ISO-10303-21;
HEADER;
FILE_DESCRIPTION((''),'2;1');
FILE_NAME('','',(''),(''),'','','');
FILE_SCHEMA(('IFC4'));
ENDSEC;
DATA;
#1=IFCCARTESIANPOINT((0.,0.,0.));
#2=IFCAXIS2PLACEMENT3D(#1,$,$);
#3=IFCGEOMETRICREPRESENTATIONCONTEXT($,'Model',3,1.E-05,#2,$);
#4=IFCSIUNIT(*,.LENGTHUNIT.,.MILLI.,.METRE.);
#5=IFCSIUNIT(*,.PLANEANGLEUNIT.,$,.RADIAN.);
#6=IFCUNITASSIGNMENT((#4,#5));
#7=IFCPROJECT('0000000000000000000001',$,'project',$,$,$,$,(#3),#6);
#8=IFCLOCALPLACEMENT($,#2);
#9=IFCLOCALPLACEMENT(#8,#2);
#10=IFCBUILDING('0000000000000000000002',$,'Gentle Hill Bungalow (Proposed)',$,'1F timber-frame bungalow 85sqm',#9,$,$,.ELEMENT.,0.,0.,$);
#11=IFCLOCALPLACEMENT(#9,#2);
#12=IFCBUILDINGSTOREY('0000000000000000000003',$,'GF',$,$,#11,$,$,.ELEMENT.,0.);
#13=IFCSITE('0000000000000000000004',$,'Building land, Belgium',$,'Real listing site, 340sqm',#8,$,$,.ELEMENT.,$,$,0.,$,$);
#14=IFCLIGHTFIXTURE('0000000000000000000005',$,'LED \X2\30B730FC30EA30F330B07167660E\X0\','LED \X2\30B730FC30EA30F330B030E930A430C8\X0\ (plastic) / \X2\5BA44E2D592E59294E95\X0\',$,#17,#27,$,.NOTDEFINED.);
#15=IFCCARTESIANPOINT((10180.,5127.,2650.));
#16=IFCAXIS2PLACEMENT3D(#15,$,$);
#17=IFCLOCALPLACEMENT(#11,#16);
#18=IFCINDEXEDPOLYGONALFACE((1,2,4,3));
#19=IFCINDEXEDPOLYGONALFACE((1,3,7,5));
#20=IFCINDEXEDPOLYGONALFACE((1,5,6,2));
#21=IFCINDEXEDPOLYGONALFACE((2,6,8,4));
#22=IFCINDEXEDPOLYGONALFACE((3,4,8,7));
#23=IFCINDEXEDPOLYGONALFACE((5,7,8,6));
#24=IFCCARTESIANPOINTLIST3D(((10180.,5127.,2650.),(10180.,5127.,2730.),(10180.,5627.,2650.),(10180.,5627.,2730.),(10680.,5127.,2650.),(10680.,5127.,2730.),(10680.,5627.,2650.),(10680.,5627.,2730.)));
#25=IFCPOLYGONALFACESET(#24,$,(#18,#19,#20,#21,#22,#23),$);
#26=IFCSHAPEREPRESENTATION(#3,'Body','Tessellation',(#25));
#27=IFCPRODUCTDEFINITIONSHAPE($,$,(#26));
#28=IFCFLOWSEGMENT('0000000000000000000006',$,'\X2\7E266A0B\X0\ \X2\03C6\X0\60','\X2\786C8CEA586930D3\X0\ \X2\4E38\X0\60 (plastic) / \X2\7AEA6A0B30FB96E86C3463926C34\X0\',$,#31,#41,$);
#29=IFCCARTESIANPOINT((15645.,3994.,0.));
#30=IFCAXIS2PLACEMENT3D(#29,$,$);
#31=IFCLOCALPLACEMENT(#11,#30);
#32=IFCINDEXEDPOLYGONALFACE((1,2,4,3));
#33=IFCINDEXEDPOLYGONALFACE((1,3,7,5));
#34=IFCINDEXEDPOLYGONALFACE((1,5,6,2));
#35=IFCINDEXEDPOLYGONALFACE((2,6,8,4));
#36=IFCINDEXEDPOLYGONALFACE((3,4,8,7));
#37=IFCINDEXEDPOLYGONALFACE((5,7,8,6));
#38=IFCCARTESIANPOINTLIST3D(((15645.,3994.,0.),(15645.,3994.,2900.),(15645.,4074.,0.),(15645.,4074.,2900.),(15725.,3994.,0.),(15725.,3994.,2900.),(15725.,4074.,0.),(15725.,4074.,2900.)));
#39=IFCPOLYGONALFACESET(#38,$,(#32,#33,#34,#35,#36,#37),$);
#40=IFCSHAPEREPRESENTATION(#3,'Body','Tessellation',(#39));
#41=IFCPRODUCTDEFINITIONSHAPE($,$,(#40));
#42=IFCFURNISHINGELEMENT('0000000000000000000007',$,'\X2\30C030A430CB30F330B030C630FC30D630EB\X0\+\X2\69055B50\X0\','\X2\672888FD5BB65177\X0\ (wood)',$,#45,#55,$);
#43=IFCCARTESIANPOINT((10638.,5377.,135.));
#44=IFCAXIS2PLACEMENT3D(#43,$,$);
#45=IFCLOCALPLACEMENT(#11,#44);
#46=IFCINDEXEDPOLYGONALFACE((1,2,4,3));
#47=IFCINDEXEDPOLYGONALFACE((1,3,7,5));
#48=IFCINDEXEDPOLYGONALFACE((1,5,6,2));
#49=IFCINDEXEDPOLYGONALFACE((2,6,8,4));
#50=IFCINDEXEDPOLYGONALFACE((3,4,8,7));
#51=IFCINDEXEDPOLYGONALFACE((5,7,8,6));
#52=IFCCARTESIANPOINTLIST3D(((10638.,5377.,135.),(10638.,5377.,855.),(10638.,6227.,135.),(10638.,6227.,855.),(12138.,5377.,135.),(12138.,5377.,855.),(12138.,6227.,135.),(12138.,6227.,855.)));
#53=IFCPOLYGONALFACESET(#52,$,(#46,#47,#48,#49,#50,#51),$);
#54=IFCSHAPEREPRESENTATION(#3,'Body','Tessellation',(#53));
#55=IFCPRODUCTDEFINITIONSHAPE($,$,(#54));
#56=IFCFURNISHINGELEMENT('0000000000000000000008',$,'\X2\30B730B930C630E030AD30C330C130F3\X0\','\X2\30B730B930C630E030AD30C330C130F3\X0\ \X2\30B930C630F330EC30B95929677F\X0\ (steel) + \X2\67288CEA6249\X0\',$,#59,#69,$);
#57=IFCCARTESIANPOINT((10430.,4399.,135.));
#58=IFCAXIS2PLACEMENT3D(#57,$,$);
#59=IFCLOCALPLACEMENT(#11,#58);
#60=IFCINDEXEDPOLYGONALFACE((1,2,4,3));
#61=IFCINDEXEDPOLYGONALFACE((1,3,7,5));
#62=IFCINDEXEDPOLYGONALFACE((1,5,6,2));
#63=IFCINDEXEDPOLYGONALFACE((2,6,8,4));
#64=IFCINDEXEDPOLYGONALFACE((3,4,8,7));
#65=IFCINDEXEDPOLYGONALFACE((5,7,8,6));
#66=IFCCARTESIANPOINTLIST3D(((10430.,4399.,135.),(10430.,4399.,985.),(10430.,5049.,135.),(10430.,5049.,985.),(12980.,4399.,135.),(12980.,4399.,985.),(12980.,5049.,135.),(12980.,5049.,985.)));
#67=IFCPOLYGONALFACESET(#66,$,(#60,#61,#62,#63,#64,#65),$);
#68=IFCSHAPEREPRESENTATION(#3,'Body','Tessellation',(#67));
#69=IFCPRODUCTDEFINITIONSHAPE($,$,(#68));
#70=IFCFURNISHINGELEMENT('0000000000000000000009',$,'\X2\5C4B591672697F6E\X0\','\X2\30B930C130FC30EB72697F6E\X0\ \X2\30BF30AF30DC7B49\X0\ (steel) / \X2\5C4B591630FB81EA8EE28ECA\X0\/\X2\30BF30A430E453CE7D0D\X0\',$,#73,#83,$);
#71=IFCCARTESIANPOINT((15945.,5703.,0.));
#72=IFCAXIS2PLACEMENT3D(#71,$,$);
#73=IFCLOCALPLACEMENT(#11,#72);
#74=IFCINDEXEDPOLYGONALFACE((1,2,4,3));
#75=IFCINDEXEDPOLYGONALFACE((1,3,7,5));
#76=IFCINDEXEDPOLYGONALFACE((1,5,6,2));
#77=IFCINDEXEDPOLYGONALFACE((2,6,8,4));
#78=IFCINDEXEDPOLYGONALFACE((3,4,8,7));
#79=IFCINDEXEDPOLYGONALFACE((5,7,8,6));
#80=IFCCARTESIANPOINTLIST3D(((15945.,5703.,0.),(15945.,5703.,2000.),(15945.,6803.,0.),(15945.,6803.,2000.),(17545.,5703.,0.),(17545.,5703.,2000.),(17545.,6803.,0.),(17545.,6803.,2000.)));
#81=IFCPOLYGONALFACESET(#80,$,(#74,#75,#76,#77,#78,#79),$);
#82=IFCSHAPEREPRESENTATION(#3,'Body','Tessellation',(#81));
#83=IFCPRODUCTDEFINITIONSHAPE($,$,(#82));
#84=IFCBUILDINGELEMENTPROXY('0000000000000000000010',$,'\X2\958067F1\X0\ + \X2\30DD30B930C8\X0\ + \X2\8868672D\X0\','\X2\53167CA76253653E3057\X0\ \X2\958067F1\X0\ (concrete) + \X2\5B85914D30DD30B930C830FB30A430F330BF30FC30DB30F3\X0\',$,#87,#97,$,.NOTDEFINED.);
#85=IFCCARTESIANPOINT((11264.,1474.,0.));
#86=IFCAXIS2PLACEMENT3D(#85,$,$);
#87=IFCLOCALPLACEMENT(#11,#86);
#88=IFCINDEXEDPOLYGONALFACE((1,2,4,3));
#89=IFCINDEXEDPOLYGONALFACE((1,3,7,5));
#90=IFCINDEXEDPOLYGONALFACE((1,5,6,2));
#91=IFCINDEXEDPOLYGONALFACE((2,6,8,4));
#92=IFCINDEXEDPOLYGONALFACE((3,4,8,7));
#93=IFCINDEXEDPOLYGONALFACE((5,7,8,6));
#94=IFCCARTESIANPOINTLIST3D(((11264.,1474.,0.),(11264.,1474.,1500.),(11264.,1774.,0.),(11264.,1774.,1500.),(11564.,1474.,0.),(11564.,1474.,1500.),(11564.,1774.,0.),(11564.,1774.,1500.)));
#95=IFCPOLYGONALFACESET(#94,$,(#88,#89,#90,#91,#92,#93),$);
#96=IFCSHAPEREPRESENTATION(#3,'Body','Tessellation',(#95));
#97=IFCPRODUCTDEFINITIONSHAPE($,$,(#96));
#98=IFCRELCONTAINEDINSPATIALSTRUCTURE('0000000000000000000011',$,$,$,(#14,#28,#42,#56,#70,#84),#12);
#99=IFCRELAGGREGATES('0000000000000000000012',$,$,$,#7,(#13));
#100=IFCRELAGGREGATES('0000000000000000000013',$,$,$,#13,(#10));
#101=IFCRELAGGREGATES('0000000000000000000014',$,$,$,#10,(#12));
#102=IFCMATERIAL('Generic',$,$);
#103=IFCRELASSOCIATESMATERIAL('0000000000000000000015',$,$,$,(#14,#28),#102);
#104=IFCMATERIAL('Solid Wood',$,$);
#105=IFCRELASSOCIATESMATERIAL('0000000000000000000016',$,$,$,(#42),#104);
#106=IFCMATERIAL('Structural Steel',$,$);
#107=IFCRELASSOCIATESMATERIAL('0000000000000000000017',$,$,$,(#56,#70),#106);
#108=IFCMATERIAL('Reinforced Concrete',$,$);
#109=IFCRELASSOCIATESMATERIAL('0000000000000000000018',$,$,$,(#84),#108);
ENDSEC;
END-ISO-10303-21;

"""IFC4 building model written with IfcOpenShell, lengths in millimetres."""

from ifc_helpers import new_model, si_unit, frame, frame_2d, origin, place, context, project, spatial, rectangle, extrude, material, element, save


model = new_model("IFC4")

# Units and contexts
model_context = context("Model", 3, precision=1e-05, world=origin())
ifc_project = project(units=[si_unit("LENGTHUNIT", "METRE", prefix="MILLI"), si_unit("PLANEANGLEUNIT", "RADIAN")], contexts=[model_context])

# Site, building, storey
site_placement = place(None, origin())
site = spatial("IfcSite", under=ifc_project, at=site_placement, Name="Building land, Belgium", ObjectType="Real listing site, 340sqm", CompositionType="ELEMENT", RefElevation=0.0)
building_placement = place(site_placement, origin())
building = spatial("IfcBuilding", under=site, at=building_placement, Name="Gentle Hill Bungalow (Proposed)", ObjectType="1F timber-frame bungalow 85sqm", CompositionType="ELEMENT", ElevationOfRefHeight=0.0, ElevationOfTerrain=0.0)
storey_placement = place(building_placement, origin())
storey = spatial("IfcBuildingStorey", under=building, at=storey_placement, Name="GF", CompositionType="ELEMENT", Elevation=0.0)

# Shared definitions
ifc_material_1 = material(Name="Solid Wood")

# Shared definitions
ifc_material_2 = material(Name="Structural Steel")

# Shared definitions
ifc_material_3 = material(Name="Reinforced Concrete")

# Shared definitions
ifc_material_4 = material(Name="Generic")

# Light fixture
light_fixture_placement = place(storey_placement, frame((10180.0, 5127.0, 2650.0)))
element("IfcLightFixture", 1, at=light_fixture_placement, inside=storey, material=ifc_material_4, Name="LED シーリング照明", Description="LED シーリングライト (plastic) / 室中央天井", PredefinedType="NOTDEFINED", context=model_context, shape_type="SweptSolid", body=[
    extrude(rectangle(XDim=500.0, YDim=500.0, at=frame_2d((250.0, 250.0))), frame((10180.0, 5127.0, 2650.0)), (0.0, 0.0, 1.0), 80.0),
])

# Flow segment
flow_segment_placement = place(storey_placement, frame((15645.0, 3994.0, 0.0)))
element("IfcFlowSegment", 2, at=flow_segment_placement, inside=storey, material=ifc_material_4, Name="縦樋 φ60", Description="硬質塩ビ 丸60 (plastic) / 竪樋・雨水排水", context=model_context, shape_type="SweptSolid", body=[
    extrude(rectangle(XDim=80.0, YDim=80.0, at=frame_2d((40.0, 40.0))), frame((15645.0, 3994.0, 0.0)), (0.0, 0.0, 1.0), 2900.0),
])

# Furnishing elements
furnishing_1_placement = place(storey_placement, frame((10638.0, 5377.0, 135.0)))
element("IfcFurnishingElement", 3, at=furnishing_1_placement, inside=storey, material=ifc_material_1, Name="ダイニングテーブル+椅子", Description="木製家具 (wood)", context=model_context, shape_type="SweptSolid", body=[
    extrude(rectangle(XDim=1500.0, YDim=850.0, at=frame_2d((750.0, 425.0))), frame((10638.0, 5377.0, 135.0)), (0.0, 0.0, 1.0), 720.0),
])
furnishing_2_placement = place(storey_placement, frame((10430.0, 4399.0, 135.0)))
element("IfcFurnishingElement", 4, at=furnishing_2_placement, inside=storey, material=ifc_material_2, Name="システムキッチン", Description="システムキッチン ステンレス天板 (steel) + 木質扉", context=model_context, shape_type="SweptSolid", body=[
    extrude(rectangle(XDim=2550.0, YDim=650.0, at=frame_2d((1275.0, 325.0))), frame((10430.0, 4399.0, 135.0)), (0.0, 0.0, 1.0), 850.0),
])
furnishing_3_placement = place(storey_placement, frame((15945.0, 5703.0, 0.0)))
element("IfcFurnishingElement", 5, at=furnishing_3_placement, inside=storey, material=ifc_material_2, Name="屋外物置", Description="スチール物置 タクボ等 (steel) / 屋外・自転車/タイヤ収納", context=model_context, shape_type="SweptSolid", body=[
    extrude(rectangle(XDim=1600.0, YDim=1100.0, at=frame_2d((800.0, 550.0))), frame((15945.0, 5703.0, 0.0)), (0.0, 0.0, 1.0), 2000.0),
])

# Building element proxy
proxy_placement = place(storey_placement, frame((11264.0, 1474.0, 0.0)))
element("IfcBuildingElementProxy", 6, at=proxy_placement, inside=storey, material=ifc_material_3, Name="門柱 + ポスト + 表札", Description="化粧打放し 門柱 (concrete) + 宅配ポスト・インターホン", PredefinedType="NOTDEFINED", context=model_context, shape_type="SweptSolid", body=[
    extrude(rectangle(XDim=300.0, YDim=300.0, at=frame_2d((150.0, 150.0))), frame((11264.0, 1474.0, 0.0)), (0.0, 0.0, 1.0), 1500.0),
])

save(model, "model.ifc")
